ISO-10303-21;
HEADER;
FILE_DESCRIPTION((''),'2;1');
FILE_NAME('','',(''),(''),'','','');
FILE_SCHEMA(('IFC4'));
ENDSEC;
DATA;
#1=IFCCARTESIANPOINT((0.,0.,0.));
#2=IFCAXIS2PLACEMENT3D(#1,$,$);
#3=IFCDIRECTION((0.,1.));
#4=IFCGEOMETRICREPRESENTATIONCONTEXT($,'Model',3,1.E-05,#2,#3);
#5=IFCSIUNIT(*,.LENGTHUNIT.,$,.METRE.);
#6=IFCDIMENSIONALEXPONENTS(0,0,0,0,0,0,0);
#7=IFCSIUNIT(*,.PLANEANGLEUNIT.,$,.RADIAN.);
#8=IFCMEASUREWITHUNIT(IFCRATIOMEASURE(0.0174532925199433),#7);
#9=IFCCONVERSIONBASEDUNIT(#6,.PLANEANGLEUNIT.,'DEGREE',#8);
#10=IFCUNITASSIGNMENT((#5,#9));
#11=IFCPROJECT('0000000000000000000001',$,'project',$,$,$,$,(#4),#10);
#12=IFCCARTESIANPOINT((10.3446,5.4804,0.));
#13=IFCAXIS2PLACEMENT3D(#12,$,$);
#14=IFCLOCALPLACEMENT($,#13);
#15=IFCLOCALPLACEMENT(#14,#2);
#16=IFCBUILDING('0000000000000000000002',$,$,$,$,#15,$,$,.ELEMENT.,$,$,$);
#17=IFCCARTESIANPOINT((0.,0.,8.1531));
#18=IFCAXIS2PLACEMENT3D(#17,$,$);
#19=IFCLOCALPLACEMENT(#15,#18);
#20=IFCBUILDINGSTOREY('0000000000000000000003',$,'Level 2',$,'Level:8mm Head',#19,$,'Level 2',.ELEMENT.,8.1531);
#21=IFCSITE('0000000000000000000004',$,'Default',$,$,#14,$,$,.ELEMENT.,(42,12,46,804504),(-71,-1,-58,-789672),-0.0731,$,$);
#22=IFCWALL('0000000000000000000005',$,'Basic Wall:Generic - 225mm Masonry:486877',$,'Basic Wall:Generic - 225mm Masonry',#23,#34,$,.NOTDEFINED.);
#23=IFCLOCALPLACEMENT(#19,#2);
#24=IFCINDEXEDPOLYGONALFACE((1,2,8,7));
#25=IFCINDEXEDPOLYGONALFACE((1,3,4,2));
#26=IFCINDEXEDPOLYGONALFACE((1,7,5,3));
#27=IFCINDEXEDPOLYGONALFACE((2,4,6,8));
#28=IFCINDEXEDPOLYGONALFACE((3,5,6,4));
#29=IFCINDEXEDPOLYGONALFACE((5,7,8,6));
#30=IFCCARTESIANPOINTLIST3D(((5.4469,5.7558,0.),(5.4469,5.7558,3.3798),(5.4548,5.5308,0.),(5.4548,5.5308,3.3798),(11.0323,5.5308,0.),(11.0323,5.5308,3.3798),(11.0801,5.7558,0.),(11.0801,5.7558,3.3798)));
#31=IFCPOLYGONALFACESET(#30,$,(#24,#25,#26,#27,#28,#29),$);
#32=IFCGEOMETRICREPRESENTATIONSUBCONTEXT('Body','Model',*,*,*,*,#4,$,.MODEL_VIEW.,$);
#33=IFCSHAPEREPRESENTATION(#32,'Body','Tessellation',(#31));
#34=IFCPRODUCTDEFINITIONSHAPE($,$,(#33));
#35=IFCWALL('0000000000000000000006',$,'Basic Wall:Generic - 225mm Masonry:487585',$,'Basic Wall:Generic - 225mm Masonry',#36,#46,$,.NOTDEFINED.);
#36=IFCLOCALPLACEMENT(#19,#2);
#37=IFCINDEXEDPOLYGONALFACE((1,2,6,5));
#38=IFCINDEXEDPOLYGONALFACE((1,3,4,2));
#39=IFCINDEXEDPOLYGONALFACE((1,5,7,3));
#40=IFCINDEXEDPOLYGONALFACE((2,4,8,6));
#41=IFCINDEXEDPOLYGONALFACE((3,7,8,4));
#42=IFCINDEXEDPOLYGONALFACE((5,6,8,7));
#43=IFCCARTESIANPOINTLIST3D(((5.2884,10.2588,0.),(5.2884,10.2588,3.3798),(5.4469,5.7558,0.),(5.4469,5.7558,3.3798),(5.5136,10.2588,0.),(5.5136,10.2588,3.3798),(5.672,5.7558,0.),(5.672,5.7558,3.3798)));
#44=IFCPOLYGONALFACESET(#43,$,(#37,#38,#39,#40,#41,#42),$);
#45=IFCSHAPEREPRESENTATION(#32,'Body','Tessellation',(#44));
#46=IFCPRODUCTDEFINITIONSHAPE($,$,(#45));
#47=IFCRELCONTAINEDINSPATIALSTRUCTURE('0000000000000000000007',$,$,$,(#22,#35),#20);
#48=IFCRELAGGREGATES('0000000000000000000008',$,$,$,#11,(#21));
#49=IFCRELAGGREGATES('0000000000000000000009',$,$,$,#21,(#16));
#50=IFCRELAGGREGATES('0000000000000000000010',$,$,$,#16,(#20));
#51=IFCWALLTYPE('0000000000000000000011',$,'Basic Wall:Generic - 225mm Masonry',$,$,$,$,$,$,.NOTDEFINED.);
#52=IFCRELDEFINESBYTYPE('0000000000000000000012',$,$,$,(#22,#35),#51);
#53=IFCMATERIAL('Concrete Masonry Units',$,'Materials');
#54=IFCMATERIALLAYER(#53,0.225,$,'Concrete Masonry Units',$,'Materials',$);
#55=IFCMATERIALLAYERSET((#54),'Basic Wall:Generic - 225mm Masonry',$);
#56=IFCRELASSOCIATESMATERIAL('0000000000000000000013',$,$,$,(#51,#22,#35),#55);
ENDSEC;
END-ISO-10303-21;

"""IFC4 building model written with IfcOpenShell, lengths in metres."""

from ifc_helpers import new_model, entity, si_unit, converted_unit, direction, frame, origin, place, context, subcontext, project, spatial, polyline, outline, extrude, clip, bounded_halfspace, material, layer, layer_set, layer_usage, type_object, element, save


model = new_model("IFC4")

# Units and contexts
model_context = context("Model", 3, precision=1e-05, world=origin(), true_north=direction((0.0, 1.0)))
body_context = subcontext(model_context, "Body", "Model", "MODEL_VIEW")
ifc_project = project(units=[si_unit("LENGTHUNIT", "METRE"), converted_unit("PLANEANGLEUNIT", "DEGREE", entity("IfcRatioMeasure", 0.0174532925199433), si_unit("PLANEANGLEUNIT", "RADIAN"), dimensions=[0, 0, 0, 0, 0, 0, 0])], contexts=[model_context])

# Site, building, storey
site_placement = place(None, frame((10.3446, 5.4804, 0.0)))
site = spatial("IfcSite", under=ifc_project, at=site_placement, Name="Default", CompositionType="ELEMENT", RefLatitude=(42, 12, 46, 804504), RefLongitude=(-71, -1, -58, -789672), RefElevation=-0.0731)
building_placement = place(site_placement, origin())
building = spatial("IfcBuilding", under=site, at=building_placement, CompositionType="ELEMENT")
storey_placement = place(building_placement, frame((0.0, 0.0, 8.1531)))
storey = spatial("IfcBuildingStorey", under=building, at=storey_placement, Name="Level 2", ObjectType="Level:8mm Head", LongName="Level 2", CompositionType="ELEMENT", Elevation=8.1531)

# Walls
ifc_material_1 = material(Name="Concrete Masonry Units", Category="Materials")
ifc_layer_1 = layer(ifc_material_1, 0.225, Name="Concrete Masonry Units", Category="Materials")
ifc_layer_set_1 = layer_set([ifc_layer_1], Name="Basic Wall:Generic - 225mm Masonry")
wall_type = type_object("IfcWallType", Name="Basic Wall:Generic - 225mm Masonry", PredefinedType="NOTDEFINED", material=ifc_layer_set_1)
ifc_layer_usage_1 = layer_usage(ifc_layer_set_1, "AXIS2", "NEGATIVE", 0.1125)
wall_1_placement = place(storey_placement, frame((11.0801, 5.6433, 0.0), z_axis=(0.0, 0.0, 1.0), x_axis=(-1.0, 0.0, 0.0)))
element("IfcWall", 1, at=wall_1_placement, inside=storey, type_object=wall_type, material=ifc_layer_usage_1, Name="Basic Wall:Generic - 225mm Masonry:486877", ObjectType="Basic Wall:Generic - 225mm Masonry", PredefinedType="NOTDEFINED", context=body_context, shape_type="Clipping", body=[
    clip(extrude(outline(polyline([(5.6333, -0.1125), (5.6254, 0.1125), (0.0478, 0.1125), (0.0, -0.1125), (5.4082, -0.1125), (5.6333, -0.1125)])), origin(), (0.0, 0.0, 1.0), 3.3798), bounded_halfspace(frame((0.0, -0.1125, 3.3798), z_axis=(0.0, 0.0, -1.0), x_axis=(0.207912, 0.978148, 0.0)), True, frame((0.0, -0.1125, 3.3798)), polyline([(0.0, 0.0), (5.4082, 0.0), (5.6333, 0.0), (5.6254, 0.225), (0.0478, 0.225), (0.0, 0.0)]))),
])
ifc_layer_usage_2 = layer_usage(ifc_layer_set_1, "AXIS2", "NEGATIVE", 0.1125)
wall_2_placement = place(storey_placement, frame((5.5596, 5.7518, 0.0), z_axis=(0.0, 0.0, 1.0), x_axis=(-0.035159, 0.999382, 0.0)))
element("IfcWall", 2, at=wall_2_placement, inside=storey, type_object=wall_type, material=ifc_layer_usage_2, Name="Basic Wall:Generic - 225mm Masonry:487585", ObjectType="Basic Wall:Generic - 225mm Masonry", PredefinedType="NOTDEFINED", context=body_context, shape_type="Clipping", body=[
    clip(extrude(outline(polyline([(4.5058, -0.1125), (4.5137, 0.1125), (0.0079, 0.1125), (0.0, -0.1125), (4.5058, -0.1125)])), origin(), (0.0, 0.0, 1.0), 3.3798), bounded_halfspace(frame((0.0, -0.1125, 3.3798), z_axis=(0.0, 0.0, -1.0), x_axis=(-0.970233, 0.242174, 0.0)), True, frame((0.0, -0.1125, 3.3798)), polyline([(0.0, 0.0), (4.5058, 0.0), (4.5137, 0.225), (0.0079, 0.225), (0.0, 0.0)]))),
])

save(model, "model.ifc")
